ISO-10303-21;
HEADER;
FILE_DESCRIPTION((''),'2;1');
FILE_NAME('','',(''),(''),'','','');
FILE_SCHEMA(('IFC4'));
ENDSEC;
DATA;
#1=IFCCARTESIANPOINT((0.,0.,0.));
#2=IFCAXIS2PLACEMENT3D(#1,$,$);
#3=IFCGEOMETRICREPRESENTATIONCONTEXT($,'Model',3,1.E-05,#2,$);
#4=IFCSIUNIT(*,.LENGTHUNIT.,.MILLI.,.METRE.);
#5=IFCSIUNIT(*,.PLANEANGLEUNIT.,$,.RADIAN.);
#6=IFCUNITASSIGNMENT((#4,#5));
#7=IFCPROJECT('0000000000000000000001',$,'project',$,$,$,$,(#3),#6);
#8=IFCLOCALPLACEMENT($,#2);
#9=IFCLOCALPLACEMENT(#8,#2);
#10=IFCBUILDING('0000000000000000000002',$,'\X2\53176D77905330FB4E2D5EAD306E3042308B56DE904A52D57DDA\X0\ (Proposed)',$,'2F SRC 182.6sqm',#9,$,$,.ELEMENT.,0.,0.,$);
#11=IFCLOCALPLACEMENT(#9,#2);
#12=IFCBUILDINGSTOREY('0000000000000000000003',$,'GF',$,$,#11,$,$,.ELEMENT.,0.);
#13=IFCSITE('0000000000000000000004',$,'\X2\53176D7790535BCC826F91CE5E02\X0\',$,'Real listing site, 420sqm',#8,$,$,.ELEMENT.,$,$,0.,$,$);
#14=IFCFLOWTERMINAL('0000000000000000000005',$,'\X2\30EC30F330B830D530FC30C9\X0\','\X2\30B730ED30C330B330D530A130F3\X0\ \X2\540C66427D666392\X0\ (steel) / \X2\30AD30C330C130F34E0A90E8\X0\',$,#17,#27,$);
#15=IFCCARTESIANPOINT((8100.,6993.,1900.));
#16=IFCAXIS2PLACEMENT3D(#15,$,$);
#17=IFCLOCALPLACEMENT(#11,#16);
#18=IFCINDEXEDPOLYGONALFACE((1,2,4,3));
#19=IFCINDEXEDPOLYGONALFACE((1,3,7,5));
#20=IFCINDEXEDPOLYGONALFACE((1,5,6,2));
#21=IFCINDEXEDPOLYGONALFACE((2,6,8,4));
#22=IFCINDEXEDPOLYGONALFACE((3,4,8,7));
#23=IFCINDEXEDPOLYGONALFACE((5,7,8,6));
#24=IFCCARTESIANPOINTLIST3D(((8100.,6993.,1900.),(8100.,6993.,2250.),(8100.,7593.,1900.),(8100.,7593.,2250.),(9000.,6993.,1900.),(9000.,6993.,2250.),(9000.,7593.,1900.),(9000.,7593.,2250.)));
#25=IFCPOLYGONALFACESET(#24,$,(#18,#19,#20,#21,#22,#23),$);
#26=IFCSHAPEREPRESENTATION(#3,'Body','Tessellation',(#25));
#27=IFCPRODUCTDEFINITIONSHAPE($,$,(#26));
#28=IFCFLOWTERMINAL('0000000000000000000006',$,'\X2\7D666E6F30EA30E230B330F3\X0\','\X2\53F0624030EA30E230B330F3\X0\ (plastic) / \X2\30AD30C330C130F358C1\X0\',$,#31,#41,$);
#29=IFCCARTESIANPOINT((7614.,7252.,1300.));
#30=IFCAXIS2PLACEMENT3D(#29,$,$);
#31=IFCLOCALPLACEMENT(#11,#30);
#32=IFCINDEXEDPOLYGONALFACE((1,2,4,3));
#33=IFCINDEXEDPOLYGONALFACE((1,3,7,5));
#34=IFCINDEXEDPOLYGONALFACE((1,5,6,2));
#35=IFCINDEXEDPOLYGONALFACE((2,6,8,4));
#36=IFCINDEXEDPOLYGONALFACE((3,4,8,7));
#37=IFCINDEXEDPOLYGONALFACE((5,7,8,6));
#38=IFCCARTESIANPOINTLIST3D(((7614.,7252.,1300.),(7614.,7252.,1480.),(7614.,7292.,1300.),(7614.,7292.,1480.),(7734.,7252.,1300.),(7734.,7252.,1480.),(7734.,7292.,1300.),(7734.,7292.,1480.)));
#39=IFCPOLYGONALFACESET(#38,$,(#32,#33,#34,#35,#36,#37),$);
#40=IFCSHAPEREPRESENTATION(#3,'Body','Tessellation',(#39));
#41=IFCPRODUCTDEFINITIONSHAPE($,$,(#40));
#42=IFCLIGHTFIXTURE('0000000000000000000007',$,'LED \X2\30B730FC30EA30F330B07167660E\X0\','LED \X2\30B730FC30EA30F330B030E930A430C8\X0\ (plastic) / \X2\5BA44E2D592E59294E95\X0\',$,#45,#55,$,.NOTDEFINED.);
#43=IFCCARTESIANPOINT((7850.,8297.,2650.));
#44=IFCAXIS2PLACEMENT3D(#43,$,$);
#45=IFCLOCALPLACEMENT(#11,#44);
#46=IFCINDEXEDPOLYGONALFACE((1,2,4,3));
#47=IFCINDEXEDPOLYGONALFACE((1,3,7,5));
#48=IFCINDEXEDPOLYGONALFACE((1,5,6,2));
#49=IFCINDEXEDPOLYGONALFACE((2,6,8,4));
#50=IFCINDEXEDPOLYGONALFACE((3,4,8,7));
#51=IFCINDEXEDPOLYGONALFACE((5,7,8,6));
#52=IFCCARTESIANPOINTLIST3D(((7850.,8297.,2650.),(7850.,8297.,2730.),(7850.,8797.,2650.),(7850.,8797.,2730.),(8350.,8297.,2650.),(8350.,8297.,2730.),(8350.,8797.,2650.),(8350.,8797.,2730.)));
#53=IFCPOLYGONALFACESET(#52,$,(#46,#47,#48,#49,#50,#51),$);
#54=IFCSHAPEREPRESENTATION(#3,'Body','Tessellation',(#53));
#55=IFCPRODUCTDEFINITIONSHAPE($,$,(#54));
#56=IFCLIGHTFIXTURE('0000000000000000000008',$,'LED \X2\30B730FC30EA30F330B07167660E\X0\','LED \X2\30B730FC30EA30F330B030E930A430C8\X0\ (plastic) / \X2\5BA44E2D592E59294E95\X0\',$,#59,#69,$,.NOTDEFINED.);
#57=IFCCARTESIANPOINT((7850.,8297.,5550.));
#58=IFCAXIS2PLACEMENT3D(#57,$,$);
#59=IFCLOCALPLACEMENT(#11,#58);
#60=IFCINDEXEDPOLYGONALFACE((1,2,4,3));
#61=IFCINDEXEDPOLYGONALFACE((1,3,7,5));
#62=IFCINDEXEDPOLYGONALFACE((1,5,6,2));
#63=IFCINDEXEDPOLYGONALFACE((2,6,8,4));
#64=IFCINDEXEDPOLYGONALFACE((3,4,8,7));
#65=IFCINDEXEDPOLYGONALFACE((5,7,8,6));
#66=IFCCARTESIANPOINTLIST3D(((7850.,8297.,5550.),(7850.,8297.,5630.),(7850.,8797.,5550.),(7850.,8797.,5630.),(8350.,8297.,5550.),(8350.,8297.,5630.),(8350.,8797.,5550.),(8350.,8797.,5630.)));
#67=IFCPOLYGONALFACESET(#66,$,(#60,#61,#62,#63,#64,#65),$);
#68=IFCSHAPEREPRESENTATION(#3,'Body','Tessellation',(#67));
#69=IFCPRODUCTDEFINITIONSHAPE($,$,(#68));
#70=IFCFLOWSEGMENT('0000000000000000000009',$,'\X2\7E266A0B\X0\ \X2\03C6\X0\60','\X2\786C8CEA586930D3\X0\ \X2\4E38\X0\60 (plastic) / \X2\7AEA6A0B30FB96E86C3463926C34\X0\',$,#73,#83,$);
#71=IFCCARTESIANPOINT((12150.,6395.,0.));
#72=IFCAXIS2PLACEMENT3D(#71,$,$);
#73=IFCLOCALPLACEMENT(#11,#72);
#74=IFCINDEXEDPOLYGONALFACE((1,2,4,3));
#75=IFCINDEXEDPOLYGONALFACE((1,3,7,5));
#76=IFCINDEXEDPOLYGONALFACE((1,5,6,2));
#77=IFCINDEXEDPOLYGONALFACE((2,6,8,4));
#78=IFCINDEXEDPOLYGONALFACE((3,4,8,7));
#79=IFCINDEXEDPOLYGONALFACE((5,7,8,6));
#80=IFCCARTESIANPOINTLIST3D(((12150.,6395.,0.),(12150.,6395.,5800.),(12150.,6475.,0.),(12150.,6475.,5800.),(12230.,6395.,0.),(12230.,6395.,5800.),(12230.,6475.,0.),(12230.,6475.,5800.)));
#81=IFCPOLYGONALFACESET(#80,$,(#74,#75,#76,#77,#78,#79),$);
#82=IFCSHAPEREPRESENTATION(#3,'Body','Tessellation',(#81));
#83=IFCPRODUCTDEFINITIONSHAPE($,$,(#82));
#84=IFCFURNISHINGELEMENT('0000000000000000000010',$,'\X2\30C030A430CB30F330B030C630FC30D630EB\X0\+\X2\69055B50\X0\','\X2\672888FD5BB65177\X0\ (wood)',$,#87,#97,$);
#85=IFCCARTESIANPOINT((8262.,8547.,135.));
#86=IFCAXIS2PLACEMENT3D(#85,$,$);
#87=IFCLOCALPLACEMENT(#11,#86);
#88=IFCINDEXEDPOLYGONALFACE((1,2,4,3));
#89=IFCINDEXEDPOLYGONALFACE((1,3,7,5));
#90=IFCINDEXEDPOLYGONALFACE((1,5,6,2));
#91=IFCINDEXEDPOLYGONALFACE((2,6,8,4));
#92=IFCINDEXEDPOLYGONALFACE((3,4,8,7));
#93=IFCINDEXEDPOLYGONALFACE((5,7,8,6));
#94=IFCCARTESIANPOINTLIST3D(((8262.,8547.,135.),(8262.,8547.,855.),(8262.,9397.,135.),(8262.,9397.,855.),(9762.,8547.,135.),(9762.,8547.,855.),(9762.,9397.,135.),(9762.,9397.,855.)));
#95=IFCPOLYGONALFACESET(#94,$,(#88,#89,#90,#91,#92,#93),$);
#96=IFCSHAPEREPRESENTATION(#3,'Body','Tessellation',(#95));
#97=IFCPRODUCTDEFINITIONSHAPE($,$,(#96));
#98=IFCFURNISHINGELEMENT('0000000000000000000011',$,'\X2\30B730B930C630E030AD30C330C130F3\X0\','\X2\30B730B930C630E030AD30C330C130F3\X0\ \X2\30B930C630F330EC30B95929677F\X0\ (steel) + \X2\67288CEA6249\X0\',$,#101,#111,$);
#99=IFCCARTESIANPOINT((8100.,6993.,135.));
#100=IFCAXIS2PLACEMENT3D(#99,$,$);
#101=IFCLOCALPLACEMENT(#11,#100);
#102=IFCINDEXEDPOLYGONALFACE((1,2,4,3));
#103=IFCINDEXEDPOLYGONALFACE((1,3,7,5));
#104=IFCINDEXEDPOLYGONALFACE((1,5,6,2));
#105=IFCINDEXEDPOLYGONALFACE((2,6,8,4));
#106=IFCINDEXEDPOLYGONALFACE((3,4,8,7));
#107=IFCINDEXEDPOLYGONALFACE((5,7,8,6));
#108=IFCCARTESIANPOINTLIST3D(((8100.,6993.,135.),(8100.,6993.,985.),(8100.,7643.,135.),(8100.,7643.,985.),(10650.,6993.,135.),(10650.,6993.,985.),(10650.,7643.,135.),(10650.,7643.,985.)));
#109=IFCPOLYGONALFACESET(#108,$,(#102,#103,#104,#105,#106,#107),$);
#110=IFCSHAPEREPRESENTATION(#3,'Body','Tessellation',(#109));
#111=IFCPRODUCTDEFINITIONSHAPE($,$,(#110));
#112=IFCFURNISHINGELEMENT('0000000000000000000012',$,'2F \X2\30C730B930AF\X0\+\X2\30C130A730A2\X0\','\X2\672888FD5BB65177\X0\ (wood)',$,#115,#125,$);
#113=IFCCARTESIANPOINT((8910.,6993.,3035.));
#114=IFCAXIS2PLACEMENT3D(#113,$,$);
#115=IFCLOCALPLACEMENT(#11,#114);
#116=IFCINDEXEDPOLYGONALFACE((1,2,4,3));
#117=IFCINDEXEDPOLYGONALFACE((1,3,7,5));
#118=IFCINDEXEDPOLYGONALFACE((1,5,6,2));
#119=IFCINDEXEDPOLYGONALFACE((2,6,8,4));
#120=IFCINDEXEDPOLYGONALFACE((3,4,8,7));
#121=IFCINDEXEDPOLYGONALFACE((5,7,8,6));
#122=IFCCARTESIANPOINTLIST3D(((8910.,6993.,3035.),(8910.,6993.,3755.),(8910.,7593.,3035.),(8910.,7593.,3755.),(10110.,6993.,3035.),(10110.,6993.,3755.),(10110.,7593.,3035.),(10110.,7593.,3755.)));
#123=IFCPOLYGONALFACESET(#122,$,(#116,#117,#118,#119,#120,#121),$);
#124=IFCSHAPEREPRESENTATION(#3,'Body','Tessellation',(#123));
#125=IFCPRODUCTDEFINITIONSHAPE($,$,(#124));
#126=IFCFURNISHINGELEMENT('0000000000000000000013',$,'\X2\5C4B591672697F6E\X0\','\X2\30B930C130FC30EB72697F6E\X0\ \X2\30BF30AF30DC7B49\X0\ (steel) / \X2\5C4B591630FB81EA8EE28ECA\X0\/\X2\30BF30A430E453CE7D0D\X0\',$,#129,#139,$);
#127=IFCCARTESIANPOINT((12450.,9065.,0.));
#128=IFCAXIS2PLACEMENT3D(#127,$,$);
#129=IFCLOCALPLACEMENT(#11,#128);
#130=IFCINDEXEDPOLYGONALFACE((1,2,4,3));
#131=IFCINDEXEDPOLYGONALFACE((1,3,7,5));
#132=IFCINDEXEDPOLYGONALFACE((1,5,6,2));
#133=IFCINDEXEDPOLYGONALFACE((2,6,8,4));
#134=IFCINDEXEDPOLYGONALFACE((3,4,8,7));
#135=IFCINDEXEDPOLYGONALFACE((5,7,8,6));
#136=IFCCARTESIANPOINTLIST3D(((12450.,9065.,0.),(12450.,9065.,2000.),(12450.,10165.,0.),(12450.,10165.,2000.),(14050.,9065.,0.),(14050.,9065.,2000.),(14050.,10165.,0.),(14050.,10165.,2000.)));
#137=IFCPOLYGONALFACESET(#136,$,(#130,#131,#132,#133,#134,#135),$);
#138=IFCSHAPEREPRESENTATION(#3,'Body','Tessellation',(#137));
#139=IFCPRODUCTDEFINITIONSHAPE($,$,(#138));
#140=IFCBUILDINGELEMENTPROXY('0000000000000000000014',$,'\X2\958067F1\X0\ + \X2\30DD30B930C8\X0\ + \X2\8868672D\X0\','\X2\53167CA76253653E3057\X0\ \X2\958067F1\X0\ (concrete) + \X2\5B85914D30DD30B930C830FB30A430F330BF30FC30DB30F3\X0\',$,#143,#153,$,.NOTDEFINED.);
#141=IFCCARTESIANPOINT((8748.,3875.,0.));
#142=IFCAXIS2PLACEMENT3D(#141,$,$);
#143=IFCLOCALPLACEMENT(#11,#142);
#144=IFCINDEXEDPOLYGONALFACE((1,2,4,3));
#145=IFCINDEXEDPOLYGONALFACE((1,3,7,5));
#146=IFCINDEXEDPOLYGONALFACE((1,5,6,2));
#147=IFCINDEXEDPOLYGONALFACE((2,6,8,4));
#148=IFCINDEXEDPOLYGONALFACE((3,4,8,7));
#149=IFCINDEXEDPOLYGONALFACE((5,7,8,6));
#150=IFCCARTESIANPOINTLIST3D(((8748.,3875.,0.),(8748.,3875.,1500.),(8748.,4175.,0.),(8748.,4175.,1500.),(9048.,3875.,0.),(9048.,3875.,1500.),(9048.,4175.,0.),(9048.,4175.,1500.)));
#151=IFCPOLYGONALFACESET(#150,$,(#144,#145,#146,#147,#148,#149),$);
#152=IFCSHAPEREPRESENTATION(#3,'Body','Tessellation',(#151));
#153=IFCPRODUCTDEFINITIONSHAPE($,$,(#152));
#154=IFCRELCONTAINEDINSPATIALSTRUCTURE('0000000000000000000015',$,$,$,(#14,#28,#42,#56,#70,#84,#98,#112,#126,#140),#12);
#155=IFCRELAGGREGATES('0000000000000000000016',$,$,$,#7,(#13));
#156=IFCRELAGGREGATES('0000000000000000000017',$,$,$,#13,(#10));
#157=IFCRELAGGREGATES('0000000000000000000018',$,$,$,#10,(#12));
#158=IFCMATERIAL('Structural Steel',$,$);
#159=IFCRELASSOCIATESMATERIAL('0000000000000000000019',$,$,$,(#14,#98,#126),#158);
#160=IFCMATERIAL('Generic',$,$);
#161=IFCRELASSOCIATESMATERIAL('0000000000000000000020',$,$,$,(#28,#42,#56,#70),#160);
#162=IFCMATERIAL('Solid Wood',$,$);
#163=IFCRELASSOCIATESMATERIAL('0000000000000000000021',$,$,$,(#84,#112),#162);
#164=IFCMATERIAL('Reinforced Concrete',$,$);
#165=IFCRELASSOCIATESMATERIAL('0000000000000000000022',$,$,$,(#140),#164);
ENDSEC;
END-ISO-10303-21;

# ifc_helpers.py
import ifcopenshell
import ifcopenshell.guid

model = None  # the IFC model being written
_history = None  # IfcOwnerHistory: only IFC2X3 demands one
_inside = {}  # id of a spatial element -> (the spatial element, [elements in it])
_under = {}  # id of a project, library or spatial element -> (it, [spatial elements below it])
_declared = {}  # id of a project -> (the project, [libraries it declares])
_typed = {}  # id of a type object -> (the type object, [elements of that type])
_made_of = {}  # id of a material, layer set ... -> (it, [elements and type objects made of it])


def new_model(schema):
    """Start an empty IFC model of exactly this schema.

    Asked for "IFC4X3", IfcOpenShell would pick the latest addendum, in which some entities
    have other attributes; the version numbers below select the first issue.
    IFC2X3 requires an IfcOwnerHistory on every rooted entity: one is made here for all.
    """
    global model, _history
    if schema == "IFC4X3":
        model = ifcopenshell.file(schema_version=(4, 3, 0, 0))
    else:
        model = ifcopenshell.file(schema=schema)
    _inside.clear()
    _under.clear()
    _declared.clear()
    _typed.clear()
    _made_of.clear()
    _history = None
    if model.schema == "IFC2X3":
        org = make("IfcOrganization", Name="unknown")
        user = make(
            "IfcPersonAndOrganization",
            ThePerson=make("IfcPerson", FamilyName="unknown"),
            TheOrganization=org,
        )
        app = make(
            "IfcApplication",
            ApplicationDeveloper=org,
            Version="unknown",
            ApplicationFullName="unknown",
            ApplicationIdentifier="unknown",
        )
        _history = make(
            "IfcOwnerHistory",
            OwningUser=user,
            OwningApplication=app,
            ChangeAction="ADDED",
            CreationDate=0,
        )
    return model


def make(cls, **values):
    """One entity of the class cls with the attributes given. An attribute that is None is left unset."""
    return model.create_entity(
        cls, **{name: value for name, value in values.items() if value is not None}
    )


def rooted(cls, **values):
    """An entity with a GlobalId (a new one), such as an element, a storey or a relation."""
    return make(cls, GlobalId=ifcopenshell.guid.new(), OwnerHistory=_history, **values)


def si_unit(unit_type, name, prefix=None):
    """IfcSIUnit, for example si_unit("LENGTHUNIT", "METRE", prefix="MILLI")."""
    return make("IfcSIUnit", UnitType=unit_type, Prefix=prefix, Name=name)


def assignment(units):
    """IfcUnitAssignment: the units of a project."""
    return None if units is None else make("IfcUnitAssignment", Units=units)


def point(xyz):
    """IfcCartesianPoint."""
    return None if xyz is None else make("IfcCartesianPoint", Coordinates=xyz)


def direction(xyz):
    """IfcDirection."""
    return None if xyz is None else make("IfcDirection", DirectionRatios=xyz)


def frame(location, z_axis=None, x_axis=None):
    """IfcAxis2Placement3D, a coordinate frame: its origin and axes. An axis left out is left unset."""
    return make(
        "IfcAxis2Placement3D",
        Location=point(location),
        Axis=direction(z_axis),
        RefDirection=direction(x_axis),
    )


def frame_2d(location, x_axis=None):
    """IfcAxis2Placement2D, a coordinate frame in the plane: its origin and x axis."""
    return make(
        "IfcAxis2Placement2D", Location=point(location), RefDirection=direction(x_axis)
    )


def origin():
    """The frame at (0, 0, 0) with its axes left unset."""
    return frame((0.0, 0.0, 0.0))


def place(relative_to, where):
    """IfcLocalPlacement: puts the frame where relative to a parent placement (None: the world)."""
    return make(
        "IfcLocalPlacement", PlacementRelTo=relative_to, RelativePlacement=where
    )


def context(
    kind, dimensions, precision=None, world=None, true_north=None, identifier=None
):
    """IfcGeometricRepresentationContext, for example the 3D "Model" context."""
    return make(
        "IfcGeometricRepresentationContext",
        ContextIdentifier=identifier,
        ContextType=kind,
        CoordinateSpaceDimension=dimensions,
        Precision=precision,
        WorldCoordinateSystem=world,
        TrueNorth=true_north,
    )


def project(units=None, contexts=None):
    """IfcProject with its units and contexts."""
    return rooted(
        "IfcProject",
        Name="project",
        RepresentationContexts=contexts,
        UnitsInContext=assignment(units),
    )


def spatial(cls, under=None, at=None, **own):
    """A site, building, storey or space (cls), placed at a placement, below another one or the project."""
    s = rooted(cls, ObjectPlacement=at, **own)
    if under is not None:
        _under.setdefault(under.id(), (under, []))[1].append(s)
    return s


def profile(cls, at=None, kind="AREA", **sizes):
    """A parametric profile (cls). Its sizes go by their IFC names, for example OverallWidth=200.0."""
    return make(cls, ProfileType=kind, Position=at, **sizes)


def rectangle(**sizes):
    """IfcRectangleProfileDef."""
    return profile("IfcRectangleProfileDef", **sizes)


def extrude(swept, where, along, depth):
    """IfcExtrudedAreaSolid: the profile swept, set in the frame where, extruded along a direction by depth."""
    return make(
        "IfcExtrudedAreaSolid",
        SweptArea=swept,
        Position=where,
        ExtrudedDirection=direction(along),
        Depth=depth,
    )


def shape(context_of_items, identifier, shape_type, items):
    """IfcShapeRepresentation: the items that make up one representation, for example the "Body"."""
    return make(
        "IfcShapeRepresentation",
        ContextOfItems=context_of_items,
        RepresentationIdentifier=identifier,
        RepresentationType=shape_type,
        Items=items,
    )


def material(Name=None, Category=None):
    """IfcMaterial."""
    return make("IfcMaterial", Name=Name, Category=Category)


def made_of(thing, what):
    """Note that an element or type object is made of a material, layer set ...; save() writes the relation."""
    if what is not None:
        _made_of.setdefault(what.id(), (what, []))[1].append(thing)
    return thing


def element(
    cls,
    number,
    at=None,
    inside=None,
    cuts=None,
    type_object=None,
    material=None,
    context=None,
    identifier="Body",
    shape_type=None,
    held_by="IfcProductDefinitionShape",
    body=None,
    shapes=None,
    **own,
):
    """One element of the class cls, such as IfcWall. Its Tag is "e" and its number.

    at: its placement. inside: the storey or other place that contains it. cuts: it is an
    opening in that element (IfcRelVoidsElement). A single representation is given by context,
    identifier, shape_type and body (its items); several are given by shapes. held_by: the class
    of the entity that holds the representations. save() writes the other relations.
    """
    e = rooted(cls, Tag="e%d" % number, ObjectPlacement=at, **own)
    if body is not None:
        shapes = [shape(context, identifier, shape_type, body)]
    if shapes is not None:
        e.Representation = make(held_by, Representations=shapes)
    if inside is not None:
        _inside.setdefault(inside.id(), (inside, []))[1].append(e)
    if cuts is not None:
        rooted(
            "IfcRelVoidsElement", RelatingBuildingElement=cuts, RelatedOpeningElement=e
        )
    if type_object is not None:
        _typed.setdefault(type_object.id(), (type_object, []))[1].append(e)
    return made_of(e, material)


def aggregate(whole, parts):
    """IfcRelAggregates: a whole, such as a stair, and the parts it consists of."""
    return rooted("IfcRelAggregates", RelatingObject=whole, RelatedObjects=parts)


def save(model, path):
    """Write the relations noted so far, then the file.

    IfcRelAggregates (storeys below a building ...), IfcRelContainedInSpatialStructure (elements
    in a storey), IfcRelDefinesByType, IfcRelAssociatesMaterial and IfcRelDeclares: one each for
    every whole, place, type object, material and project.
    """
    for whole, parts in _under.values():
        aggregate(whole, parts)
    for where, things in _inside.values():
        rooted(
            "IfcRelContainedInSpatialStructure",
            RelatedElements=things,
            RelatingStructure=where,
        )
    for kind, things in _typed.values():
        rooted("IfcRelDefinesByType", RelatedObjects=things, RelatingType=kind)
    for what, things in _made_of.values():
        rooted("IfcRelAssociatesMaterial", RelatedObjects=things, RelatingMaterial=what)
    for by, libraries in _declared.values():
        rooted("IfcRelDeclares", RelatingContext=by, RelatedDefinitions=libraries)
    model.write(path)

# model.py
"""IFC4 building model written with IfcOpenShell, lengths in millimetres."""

from ifc_helpers import new_model, si_unit, frame, frame_2d, origin, place, context, project, spatial, rectangle, extrude, material, element, save


model = new_model("IFC4")

# Units and contexts
model_context = context("Model", 3, precision=1e-05, world=origin())
ifc_project = project(units=[si_unit("LENGTHUNIT", "METRE", prefix="MILLI"), si_unit("PLANEANGLEUNIT", "RADIAN")], contexts=[model_context])

# Site, building, storey
site_placement = place(None, origin())
site = spatial("IfcSite", under=ifc_project, at=site_placement, Name="北海道富良野市", ObjectType="Real listing site, 420sqm", CompositionType="ELEMENT", RefElevation=0.0)
building_placement = place(site_placement, origin())
building = spatial("IfcBuilding", under=site, at=building_placement, Name="北海道・中庭のある回遊動線 (Proposed)", ObjectType="2F SRC 182.6sqm", CompositionType="ELEMENT", ElevationOfRefHeight=0.0, ElevationOfTerrain=0.0)
storey_placement = place(building_placement, origin())
storey = spatial("IfcBuildingStorey", under=building, at=storey_placement, Name="GF", CompositionType="ELEMENT", Elevation=0.0)

# Shared definitions
ifc_material_1 = material(Name="Solid Wood")

# Shared definitions
ifc_material_2 = material(Name="Reinforced Concrete")

# Shared definitions
ifc_material_3 = material(Name="Structural Steel")

# Flow terminals
flow_terminal_1_placement = place(storey_placement, frame((8100.0, 6993.0, 1900.0)))
element("IfcFlowTerminal", 1, at=flow_terminal_1_placement, inside=storey, material=ifc_material_3, Name="レンジフード", Description="シロッコファン 同時給排 (steel) / キッチン上部", context=model_context, shape_type="SweptSolid", body=[
    extrude(rectangle(XDim=900.0, YDim=600.0, at=frame_2d((450.0, 300.0))), frame((8100.0, 6993.0, 1900.0)), (0.0, 0.0, 1.0), 350.0),
])
ifc_material_4 = material(Name="Generic")
flow_terminal_2_placement = place(storey_placement, frame((7614.0, 7252.0, 1300.0)))
element("IfcFlowTerminal", 2, at=flow_terminal_2_placement, inside=storey, material=ifc_material_4, Name="給湯リモコン", Description="台所リモコン (plastic) / キッチン壁", context=model_context, shape_type="SweptSolid", body=[
    extrude(rectangle(XDim=120.0, YDim=40.0, at=frame_2d((60.0, 20.0))), frame((7614.0, 7252.0, 1300.0)), (0.0, 0.0, 1.0), 180.0),
])

# Light fixtures
light_fixture_1_placement = place(storey_placement, frame((7850.0, 8297.0, 2650.0)))
element("IfcLightFixture", 3, at=light_fixture_1_placement, inside=storey, material=ifc_material_4, Name="LED シーリング照明", Description="LED シーリングライト (plastic) / 室中央天井", PredefinedType="NOTDEFINED", context=model_context, shape_type="SweptSolid", body=[
    extrude(rectangle(XDim=500.0, YDim=500.0, at=frame_2d((250.0, 250.0))), frame((7850.0, 8297.0, 2650.0)), (0.0, 0.0, 1.0), 80.0),
])
light_fixture_2_placement = place(storey_placement, frame((7850.0, 8297.0, 5550.0)))
element("IfcLightFixture", 4, at=light_fixture_2_placement, inside=storey, material=ifc_material_4, Name="LED シーリング照明", Description="LED シーリングライト (plastic) / 室中央天井", PredefinedType="NOTDEFINED", context=model_context, shape_type="SweptSolid", body=[
    extrude(rectangle(XDim=500.0, YDim=500.0, at=frame_2d((250.0, 250.0))), frame((7850.0, 8297.0, 5550.0)), (0.0, 0.0, 1.0), 80.0),
])

# Flow segment
flow_segment_placement = place(storey_placement, frame((12150.0, 6395.0, 0.0)))
element("IfcFlowSegment", 5, at=flow_segment_placement, inside=storey, material=ifc_material_4, Name="縦樋 φ60", Description="硬質塩ビ 丸60 (plastic) / 竪樋・雨水排水", context=model_context, shape_type="SweptSolid", body=[
    extrude(rectangle(XDim=80.0, YDim=80.0, at=frame_2d((40.0, 40.0))), frame((12150.0, 6395.0, 0.0)), (0.0, 0.0, 1.0), 5800.0),
])

# Furnishing elements
furnishing_1_placement = place(storey_placement, frame((8262.0, 8547.0, 135.0)))
element("IfcFurnishingElement", 6, at=furnishing_1_placement, inside=storey, material=ifc_material_1, Name="ダイニングテーブル+椅子", Description="木製家具 (wood)", context=model_context, shape_type="SweptSolid", body=[
    extrude(rectangle(XDim=1500.0, YDim=850.0, at=frame_2d((750.0, 425.0))), frame((8262.0, 8547.0, 135.0)), (0.0, 0.0, 1.0), 720.0),
])
furnishing_2_placement = place(storey_placement, frame((8100.0, 6993.0, 135.0)))
element("IfcFurnishingElement", 7, at=furnishing_2_placement, inside=storey, material=ifc_material_3, Name="システムキッチン", Description="システムキッチン ステンレス天板 (steel) + 木質扉", context=model_context, shape_type="SweptSolid", body=[
    extrude(rectangle(XDim=2550.0, YDim=650.0, at=frame_2d((1275.0, 325.0))), frame((8100.0, 6993.0, 135.0)), (0.0, 0.0, 1.0), 850.0),
])
furnishing_3_placement = place(storey_placement, frame((8910.0, 6993.0, 3035.0)))
element("IfcFurnishingElement", 8, at=furnishing_3_placement, inside=storey, material=ifc_material_1, Name="2F デスク+チェア", Description="木製家具 (wood)", context=model_context, shape_type="SweptSolid", body=[
    extrude(rectangle(XDim=1200.0, YDim=600.0, at=frame_2d((600.0, 300.0))), frame((8910.0, 6993.0, 3035.0)), (0.0, 0.0, 1.0), 720.0),
])
furnishing_4_placement = place(storey_placement, frame((12450.0, 9065.0, 0.0)))
element("IfcFurnishingElement", 9, at=furnishing_4_placement, inside=storey, material=ifc_material_3, Name="屋外物置", Description="スチール物置 タクボ等 (steel) / 屋外・自転車/タイヤ収納", context=model_context, shape_type="SweptSolid", body=[
    extrude(rectangle(XDim=1600.0, YDim=1100.0, at=frame_2d((800.0, 550.0))), frame((12450.0, 9065.0, 0.0)), (0.0, 0.0, 1.0), 2000.0),
])

# Building element proxy
proxy_placement = place(storey_placement, frame((8748.0, 3875.0, 0.0)))
element("IfcBuildingElementProxy", 10, at=proxy_placement, inside=storey, material=ifc_material_2, Name="門柱 + ポスト + 表札", Description="化粧打放し 門柱 (concrete) + 宅配ポスト・インターホン", PredefinedType="NOTDEFINED", context=model_context, shape_type="SweptSolid", body=[
    extrude(rectangle(XDim=300.0, YDim=300.0, at=frame_2d((150.0, 150.0))), frame((8748.0, 3875.0, 0.0)), (0.0, 0.0, 1.0), 1500.0),
])

save(model, "model.ifc")
